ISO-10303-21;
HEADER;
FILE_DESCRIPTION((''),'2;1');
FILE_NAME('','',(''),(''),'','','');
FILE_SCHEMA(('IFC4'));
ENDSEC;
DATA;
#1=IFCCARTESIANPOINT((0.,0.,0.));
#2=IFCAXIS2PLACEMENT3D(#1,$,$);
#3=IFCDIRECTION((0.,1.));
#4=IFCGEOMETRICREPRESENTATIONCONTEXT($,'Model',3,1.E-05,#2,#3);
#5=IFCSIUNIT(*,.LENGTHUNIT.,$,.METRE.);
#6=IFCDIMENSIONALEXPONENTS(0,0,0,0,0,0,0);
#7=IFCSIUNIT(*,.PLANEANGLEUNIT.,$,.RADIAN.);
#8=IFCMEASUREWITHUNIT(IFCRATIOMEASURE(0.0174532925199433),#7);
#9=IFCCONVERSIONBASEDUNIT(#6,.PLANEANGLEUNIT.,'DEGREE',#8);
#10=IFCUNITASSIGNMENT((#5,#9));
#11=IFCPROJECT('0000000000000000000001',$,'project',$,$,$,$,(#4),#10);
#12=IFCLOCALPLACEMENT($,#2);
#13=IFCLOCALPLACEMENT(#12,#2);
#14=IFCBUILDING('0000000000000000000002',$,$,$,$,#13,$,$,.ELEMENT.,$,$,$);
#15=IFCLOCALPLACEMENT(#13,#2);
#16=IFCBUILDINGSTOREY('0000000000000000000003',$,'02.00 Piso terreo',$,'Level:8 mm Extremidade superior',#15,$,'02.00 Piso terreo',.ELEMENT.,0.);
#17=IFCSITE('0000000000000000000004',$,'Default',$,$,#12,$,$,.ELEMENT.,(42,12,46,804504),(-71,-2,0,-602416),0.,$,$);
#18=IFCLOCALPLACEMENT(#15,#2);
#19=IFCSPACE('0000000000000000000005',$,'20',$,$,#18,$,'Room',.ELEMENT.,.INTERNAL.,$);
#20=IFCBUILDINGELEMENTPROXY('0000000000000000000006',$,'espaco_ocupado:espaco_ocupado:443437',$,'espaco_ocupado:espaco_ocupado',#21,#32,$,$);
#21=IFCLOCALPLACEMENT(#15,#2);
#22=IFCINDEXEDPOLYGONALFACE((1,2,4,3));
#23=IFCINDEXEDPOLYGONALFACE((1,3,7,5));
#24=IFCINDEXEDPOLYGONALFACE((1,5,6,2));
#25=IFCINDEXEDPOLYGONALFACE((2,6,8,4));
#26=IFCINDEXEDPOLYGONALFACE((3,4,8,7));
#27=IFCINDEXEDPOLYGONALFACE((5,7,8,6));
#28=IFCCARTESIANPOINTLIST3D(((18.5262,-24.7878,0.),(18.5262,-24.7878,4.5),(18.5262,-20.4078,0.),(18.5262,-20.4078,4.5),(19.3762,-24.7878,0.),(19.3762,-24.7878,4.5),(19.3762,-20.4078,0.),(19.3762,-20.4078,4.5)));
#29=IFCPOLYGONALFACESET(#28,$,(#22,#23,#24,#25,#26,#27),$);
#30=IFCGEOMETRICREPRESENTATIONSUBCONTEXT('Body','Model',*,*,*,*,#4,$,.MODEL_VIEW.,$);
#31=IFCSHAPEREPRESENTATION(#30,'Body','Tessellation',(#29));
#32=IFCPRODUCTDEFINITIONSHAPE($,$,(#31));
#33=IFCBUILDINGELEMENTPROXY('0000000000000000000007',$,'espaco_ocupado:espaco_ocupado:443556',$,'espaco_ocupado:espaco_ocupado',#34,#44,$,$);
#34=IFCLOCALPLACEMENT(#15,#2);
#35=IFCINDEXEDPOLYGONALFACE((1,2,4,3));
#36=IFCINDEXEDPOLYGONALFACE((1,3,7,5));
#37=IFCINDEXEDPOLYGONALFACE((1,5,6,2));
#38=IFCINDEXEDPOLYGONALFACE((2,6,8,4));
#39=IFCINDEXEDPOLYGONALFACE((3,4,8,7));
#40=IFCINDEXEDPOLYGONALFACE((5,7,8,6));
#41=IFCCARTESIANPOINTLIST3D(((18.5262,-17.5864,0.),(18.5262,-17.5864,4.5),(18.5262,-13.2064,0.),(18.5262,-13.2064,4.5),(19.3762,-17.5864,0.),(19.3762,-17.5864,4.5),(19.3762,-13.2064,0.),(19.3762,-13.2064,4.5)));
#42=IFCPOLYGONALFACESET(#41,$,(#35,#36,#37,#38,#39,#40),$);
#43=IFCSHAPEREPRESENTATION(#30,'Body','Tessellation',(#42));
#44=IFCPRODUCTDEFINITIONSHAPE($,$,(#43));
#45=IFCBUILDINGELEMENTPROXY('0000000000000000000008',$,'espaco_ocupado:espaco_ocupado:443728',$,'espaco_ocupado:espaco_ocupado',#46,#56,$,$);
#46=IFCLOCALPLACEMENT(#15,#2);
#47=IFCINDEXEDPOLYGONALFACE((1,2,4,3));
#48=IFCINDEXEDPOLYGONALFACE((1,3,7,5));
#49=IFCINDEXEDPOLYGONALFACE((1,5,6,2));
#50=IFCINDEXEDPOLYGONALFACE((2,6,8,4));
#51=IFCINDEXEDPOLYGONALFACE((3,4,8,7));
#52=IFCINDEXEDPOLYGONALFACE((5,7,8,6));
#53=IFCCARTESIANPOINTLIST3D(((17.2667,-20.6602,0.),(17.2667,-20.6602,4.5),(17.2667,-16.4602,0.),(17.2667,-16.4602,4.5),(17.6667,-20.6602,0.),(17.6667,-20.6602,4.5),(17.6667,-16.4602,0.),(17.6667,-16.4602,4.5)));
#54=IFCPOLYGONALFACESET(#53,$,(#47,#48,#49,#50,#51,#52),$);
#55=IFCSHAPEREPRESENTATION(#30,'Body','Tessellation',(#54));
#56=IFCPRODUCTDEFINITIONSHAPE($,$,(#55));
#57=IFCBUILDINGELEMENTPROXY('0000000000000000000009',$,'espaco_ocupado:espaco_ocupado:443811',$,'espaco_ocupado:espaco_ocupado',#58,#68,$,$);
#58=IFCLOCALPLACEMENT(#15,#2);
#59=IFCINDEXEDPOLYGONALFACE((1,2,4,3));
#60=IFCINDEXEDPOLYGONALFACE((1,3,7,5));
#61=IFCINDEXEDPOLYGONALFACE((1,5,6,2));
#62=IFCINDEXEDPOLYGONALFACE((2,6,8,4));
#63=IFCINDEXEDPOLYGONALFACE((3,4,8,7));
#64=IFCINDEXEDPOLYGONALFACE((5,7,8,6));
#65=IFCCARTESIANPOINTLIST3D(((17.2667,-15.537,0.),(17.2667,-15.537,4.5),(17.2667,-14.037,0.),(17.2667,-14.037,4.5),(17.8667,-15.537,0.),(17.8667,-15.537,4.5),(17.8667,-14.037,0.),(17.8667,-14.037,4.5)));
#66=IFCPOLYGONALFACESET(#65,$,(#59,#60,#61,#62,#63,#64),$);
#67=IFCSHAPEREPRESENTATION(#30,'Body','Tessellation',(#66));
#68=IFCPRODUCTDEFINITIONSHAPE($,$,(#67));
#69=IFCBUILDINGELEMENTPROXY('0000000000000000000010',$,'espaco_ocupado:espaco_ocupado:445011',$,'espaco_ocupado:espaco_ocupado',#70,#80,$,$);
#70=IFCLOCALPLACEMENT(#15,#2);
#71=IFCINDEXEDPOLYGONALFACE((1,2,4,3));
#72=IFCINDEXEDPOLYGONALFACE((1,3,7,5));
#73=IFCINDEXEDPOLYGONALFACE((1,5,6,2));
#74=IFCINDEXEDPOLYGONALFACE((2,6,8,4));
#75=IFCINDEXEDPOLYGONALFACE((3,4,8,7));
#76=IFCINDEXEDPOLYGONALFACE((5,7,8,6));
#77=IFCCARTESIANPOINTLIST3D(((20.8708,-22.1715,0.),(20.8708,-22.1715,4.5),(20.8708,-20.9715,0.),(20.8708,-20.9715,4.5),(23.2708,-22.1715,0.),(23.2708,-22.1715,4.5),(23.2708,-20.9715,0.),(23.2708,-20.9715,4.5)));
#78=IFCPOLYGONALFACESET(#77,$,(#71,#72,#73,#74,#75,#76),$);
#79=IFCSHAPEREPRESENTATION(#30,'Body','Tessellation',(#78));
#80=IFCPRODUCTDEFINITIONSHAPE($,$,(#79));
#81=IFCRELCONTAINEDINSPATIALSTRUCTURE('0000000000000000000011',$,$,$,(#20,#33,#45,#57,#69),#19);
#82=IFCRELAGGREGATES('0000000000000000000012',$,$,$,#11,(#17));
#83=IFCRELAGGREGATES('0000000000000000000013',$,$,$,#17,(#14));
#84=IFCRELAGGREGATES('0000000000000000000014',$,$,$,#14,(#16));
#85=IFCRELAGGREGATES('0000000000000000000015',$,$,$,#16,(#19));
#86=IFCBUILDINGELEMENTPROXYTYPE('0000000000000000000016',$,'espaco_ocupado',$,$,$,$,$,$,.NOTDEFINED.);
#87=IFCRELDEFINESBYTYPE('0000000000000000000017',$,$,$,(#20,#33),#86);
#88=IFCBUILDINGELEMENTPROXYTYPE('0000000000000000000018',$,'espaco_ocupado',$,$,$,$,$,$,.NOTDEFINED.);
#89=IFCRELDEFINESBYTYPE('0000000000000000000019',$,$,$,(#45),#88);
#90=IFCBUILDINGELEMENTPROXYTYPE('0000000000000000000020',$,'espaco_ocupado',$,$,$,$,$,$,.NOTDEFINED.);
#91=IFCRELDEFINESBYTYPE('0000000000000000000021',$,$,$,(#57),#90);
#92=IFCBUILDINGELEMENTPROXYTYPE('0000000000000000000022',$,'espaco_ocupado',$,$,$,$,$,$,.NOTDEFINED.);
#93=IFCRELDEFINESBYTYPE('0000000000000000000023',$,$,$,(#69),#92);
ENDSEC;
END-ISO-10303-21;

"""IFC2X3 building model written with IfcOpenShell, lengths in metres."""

from ifc_helpers import new_model, entity, si_unit, converted_unit, direction, frame, frame_2d, origin, origin_2d_with_axis, place, context, subcontext, project, spatial, rectangle, extrude, source, transform, mapped, type_object, type_shapes, element, save


model = new_model("IFC2X3")

# Units and contexts
model_context = context("Model", 3, precision=1e-05, world=origin(), true_north=direction((0.0, 1.0)))
body_context = subcontext(model_context, "Body", "Model", "MODEL_VIEW")
ifc_project = project(units=[si_unit("LENGTHUNIT", "METRE"), converted_unit("PLANEANGLEUNIT", "DEGREE", entity("IfcRatioMeasure", 0.0174532925199433), si_unit("PLANEANGLEUNIT", "RADIAN"), dimensions=[0, 0, 0, 0, 0, 0, 0])], contexts=[model_context])

# Site, building, storey
site_placement = place(None, origin())
site = spatial("IfcSite", under=ifc_project, at=site_placement, Name="Default", CompositionType="ELEMENT", RefLatitude=(42, 12, 46, 804504), RefLongitude=(-71, -2, 0, -602416), RefElevation=0.0)
building_placement = place(site_placement, origin())
building = spatial("IfcBuilding", under=site, at=building_placement, CompositionType="ELEMENT")
storey_placement = place(building_placement, origin())
storey = spatial("IfcBuildingStorey", under=building, at=storey_placement, Name="02.00 Piso terreo", ObjectType="Level:8 mm Extremidade superior", LongName="02.00 Piso terreo", CompositionType="ELEMENT", Elevation=0.0)

# Shared definitions
space_1_placement = place(storey_placement, origin())
space_1 = spatial("IfcSpace", under=storey, at=space_1_placement, Name="20", LongName="Room", CompositionType="ELEMENT", InteriorOrExteriorSpace="INTERNAL")

# Building element proxies
building_element_proxy_type_1 = type_object("IfcBuildingElementProxyType", Name="espaco_ocupado", PredefinedType="NOTDEFINED")
shared_shape_1 = source(origin(), body_context, "Body", "SweptSolid", [
    extrude(rectangle(XDim=0.85, YDim=4.38, at=frame_2d((0.0, 0.0), x_axis=(1.0, 0.0))), frame((0.0, 0.0, 0.0), z_axis=(0.0, 0.0, 1.0), x_axis=(-1.0, 0.0, 0.0)), (0.0, 0.0, 1.0), 4.5),
])
type_shapes(building_element_proxy_type_1, [shared_shape_1])
for number, where, name in (
    (1, (18.9512, -22.5978, 0.0), "espaco_ocupado:espaco_ocupado:443437"),
    (2, (18.9512, -15.3964, 0.0), "espaco_ocupado:espaco_ocupado:443556"),
):
    element("IfcBuildingElementProxy", number, at=place(space_1_placement, frame(where)), inside=space_1, type_object=building_element_proxy_type_1, Name=name, ObjectType="espaco_ocupado:espaco_ocupado", context=body_context, shape_type="MappedRepresentation", body=[
        mapped(shared_shape_1, transform((0.0, 0.0, 0.0), scale=1.0)),
    ])
building_element_proxy_type_2 = type_object("IfcBuildingElementProxyType", Name="espaco_ocupado", PredefinedType="NOTDEFINED")
shared_shape_2 = source(origin(), body_context, "Body", "SweptSolid", [
    extrude(rectangle(XDim=0.4, YDim=4.2, at=origin_2d_with_axis()), frame((0.0, 0.0, 0.0), z_axis=(0.0, 0.0, 1.0), x_axis=(-1.0, 0.0, 0.0)), (0.0, 0.0, 1.0), 4.5),
])
type_shapes(building_element_proxy_type_2, [shared_shape_2])
proxy_1_placement = place(space_1_placement, frame((17.4667, -18.5602, 0.0)))
element("IfcBuildingElementProxy", 3, at=proxy_1_placement, inside=space_1, type_object=building_element_proxy_type_2, Name="espaco_ocupado:espaco_ocupado:443728", ObjectType="espaco_ocupado:espaco_ocupado", context=body_context, shape_type="MappedRepresentation", body=[
    mapped(shared_shape_2, transform((0.0, 0.0, 0.0), scale=1.0)),
])
building_element_proxy_type_3 = type_object("IfcBuildingElementProxyType", Name="espaco_ocupado", PredefinedType="NOTDEFINED")
shared_shape_3 = source(origin(), body_context, "Body", "SweptSolid", [
    extrude(rectangle(XDim=0.6, YDim=1.5, at=origin_2d_with_axis()), frame((0.0, 0.0, 0.0), z_axis=(0.0, 0.0, 1.0), x_axis=(-1.0, 0.0, 0.0)), (0.0, 0.0, 1.0), 4.5),
])
type_shapes(building_element_proxy_type_3, [shared_shape_3])
proxy_2_placement = place(space_1_placement, frame((17.5667, -14.787, 0.0)))
element("IfcBuildingElementProxy", 4, at=proxy_2_placement, inside=space_1, type_object=building_element_proxy_type_3, Name="espaco_ocupado:espaco_ocupado:443811", ObjectType="espaco_ocupado:espaco_ocupado", context=body_context, shape_type="MappedRepresentation", body=[
    mapped(shared_shape_3, transform((0.0, 0.0, 0.0), scale=1.0)),
])
building_element_proxy_type_4 = type_object("IfcBuildingElementProxyType", Name="espaco_ocupado", PredefinedType="NOTDEFINED")
shared_shape_4 = source(origin(), body_context, "Body", "SweptSolid", [
    extrude(rectangle(XDim=2.4, YDim=1.2, at=origin_2d_with_axis()), frame((0.0, 0.0, 0.0), z_axis=(0.0, 0.0, 1.0), x_axis=(-1.0, 0.0, 0.0)), (0.0, 0.0, 1.0), 4.5),
])
type_shapes(building_element_proxy_type_4, [shared_shape_4])
proxy_3_placement = place(space_1_placement, frame((22.0708, -21.5715, 0.0)))
element("IfcBuildingElementProxy", 5, at=proxy_3_placement, inside=space_1, type_object=building_element_proxy_type_4, Name="espaco_ocupado:espaco_ocupado:445011", ObjectType="espaco_ocupado:espaco_ocupado", context=body_context, shape_type="MappedRepresentation", body=[
    mapped(shared_shape_4, transform((0.0, 0.0, 0.0), scale=1.0)),
])

save(model, "model.ifc")
